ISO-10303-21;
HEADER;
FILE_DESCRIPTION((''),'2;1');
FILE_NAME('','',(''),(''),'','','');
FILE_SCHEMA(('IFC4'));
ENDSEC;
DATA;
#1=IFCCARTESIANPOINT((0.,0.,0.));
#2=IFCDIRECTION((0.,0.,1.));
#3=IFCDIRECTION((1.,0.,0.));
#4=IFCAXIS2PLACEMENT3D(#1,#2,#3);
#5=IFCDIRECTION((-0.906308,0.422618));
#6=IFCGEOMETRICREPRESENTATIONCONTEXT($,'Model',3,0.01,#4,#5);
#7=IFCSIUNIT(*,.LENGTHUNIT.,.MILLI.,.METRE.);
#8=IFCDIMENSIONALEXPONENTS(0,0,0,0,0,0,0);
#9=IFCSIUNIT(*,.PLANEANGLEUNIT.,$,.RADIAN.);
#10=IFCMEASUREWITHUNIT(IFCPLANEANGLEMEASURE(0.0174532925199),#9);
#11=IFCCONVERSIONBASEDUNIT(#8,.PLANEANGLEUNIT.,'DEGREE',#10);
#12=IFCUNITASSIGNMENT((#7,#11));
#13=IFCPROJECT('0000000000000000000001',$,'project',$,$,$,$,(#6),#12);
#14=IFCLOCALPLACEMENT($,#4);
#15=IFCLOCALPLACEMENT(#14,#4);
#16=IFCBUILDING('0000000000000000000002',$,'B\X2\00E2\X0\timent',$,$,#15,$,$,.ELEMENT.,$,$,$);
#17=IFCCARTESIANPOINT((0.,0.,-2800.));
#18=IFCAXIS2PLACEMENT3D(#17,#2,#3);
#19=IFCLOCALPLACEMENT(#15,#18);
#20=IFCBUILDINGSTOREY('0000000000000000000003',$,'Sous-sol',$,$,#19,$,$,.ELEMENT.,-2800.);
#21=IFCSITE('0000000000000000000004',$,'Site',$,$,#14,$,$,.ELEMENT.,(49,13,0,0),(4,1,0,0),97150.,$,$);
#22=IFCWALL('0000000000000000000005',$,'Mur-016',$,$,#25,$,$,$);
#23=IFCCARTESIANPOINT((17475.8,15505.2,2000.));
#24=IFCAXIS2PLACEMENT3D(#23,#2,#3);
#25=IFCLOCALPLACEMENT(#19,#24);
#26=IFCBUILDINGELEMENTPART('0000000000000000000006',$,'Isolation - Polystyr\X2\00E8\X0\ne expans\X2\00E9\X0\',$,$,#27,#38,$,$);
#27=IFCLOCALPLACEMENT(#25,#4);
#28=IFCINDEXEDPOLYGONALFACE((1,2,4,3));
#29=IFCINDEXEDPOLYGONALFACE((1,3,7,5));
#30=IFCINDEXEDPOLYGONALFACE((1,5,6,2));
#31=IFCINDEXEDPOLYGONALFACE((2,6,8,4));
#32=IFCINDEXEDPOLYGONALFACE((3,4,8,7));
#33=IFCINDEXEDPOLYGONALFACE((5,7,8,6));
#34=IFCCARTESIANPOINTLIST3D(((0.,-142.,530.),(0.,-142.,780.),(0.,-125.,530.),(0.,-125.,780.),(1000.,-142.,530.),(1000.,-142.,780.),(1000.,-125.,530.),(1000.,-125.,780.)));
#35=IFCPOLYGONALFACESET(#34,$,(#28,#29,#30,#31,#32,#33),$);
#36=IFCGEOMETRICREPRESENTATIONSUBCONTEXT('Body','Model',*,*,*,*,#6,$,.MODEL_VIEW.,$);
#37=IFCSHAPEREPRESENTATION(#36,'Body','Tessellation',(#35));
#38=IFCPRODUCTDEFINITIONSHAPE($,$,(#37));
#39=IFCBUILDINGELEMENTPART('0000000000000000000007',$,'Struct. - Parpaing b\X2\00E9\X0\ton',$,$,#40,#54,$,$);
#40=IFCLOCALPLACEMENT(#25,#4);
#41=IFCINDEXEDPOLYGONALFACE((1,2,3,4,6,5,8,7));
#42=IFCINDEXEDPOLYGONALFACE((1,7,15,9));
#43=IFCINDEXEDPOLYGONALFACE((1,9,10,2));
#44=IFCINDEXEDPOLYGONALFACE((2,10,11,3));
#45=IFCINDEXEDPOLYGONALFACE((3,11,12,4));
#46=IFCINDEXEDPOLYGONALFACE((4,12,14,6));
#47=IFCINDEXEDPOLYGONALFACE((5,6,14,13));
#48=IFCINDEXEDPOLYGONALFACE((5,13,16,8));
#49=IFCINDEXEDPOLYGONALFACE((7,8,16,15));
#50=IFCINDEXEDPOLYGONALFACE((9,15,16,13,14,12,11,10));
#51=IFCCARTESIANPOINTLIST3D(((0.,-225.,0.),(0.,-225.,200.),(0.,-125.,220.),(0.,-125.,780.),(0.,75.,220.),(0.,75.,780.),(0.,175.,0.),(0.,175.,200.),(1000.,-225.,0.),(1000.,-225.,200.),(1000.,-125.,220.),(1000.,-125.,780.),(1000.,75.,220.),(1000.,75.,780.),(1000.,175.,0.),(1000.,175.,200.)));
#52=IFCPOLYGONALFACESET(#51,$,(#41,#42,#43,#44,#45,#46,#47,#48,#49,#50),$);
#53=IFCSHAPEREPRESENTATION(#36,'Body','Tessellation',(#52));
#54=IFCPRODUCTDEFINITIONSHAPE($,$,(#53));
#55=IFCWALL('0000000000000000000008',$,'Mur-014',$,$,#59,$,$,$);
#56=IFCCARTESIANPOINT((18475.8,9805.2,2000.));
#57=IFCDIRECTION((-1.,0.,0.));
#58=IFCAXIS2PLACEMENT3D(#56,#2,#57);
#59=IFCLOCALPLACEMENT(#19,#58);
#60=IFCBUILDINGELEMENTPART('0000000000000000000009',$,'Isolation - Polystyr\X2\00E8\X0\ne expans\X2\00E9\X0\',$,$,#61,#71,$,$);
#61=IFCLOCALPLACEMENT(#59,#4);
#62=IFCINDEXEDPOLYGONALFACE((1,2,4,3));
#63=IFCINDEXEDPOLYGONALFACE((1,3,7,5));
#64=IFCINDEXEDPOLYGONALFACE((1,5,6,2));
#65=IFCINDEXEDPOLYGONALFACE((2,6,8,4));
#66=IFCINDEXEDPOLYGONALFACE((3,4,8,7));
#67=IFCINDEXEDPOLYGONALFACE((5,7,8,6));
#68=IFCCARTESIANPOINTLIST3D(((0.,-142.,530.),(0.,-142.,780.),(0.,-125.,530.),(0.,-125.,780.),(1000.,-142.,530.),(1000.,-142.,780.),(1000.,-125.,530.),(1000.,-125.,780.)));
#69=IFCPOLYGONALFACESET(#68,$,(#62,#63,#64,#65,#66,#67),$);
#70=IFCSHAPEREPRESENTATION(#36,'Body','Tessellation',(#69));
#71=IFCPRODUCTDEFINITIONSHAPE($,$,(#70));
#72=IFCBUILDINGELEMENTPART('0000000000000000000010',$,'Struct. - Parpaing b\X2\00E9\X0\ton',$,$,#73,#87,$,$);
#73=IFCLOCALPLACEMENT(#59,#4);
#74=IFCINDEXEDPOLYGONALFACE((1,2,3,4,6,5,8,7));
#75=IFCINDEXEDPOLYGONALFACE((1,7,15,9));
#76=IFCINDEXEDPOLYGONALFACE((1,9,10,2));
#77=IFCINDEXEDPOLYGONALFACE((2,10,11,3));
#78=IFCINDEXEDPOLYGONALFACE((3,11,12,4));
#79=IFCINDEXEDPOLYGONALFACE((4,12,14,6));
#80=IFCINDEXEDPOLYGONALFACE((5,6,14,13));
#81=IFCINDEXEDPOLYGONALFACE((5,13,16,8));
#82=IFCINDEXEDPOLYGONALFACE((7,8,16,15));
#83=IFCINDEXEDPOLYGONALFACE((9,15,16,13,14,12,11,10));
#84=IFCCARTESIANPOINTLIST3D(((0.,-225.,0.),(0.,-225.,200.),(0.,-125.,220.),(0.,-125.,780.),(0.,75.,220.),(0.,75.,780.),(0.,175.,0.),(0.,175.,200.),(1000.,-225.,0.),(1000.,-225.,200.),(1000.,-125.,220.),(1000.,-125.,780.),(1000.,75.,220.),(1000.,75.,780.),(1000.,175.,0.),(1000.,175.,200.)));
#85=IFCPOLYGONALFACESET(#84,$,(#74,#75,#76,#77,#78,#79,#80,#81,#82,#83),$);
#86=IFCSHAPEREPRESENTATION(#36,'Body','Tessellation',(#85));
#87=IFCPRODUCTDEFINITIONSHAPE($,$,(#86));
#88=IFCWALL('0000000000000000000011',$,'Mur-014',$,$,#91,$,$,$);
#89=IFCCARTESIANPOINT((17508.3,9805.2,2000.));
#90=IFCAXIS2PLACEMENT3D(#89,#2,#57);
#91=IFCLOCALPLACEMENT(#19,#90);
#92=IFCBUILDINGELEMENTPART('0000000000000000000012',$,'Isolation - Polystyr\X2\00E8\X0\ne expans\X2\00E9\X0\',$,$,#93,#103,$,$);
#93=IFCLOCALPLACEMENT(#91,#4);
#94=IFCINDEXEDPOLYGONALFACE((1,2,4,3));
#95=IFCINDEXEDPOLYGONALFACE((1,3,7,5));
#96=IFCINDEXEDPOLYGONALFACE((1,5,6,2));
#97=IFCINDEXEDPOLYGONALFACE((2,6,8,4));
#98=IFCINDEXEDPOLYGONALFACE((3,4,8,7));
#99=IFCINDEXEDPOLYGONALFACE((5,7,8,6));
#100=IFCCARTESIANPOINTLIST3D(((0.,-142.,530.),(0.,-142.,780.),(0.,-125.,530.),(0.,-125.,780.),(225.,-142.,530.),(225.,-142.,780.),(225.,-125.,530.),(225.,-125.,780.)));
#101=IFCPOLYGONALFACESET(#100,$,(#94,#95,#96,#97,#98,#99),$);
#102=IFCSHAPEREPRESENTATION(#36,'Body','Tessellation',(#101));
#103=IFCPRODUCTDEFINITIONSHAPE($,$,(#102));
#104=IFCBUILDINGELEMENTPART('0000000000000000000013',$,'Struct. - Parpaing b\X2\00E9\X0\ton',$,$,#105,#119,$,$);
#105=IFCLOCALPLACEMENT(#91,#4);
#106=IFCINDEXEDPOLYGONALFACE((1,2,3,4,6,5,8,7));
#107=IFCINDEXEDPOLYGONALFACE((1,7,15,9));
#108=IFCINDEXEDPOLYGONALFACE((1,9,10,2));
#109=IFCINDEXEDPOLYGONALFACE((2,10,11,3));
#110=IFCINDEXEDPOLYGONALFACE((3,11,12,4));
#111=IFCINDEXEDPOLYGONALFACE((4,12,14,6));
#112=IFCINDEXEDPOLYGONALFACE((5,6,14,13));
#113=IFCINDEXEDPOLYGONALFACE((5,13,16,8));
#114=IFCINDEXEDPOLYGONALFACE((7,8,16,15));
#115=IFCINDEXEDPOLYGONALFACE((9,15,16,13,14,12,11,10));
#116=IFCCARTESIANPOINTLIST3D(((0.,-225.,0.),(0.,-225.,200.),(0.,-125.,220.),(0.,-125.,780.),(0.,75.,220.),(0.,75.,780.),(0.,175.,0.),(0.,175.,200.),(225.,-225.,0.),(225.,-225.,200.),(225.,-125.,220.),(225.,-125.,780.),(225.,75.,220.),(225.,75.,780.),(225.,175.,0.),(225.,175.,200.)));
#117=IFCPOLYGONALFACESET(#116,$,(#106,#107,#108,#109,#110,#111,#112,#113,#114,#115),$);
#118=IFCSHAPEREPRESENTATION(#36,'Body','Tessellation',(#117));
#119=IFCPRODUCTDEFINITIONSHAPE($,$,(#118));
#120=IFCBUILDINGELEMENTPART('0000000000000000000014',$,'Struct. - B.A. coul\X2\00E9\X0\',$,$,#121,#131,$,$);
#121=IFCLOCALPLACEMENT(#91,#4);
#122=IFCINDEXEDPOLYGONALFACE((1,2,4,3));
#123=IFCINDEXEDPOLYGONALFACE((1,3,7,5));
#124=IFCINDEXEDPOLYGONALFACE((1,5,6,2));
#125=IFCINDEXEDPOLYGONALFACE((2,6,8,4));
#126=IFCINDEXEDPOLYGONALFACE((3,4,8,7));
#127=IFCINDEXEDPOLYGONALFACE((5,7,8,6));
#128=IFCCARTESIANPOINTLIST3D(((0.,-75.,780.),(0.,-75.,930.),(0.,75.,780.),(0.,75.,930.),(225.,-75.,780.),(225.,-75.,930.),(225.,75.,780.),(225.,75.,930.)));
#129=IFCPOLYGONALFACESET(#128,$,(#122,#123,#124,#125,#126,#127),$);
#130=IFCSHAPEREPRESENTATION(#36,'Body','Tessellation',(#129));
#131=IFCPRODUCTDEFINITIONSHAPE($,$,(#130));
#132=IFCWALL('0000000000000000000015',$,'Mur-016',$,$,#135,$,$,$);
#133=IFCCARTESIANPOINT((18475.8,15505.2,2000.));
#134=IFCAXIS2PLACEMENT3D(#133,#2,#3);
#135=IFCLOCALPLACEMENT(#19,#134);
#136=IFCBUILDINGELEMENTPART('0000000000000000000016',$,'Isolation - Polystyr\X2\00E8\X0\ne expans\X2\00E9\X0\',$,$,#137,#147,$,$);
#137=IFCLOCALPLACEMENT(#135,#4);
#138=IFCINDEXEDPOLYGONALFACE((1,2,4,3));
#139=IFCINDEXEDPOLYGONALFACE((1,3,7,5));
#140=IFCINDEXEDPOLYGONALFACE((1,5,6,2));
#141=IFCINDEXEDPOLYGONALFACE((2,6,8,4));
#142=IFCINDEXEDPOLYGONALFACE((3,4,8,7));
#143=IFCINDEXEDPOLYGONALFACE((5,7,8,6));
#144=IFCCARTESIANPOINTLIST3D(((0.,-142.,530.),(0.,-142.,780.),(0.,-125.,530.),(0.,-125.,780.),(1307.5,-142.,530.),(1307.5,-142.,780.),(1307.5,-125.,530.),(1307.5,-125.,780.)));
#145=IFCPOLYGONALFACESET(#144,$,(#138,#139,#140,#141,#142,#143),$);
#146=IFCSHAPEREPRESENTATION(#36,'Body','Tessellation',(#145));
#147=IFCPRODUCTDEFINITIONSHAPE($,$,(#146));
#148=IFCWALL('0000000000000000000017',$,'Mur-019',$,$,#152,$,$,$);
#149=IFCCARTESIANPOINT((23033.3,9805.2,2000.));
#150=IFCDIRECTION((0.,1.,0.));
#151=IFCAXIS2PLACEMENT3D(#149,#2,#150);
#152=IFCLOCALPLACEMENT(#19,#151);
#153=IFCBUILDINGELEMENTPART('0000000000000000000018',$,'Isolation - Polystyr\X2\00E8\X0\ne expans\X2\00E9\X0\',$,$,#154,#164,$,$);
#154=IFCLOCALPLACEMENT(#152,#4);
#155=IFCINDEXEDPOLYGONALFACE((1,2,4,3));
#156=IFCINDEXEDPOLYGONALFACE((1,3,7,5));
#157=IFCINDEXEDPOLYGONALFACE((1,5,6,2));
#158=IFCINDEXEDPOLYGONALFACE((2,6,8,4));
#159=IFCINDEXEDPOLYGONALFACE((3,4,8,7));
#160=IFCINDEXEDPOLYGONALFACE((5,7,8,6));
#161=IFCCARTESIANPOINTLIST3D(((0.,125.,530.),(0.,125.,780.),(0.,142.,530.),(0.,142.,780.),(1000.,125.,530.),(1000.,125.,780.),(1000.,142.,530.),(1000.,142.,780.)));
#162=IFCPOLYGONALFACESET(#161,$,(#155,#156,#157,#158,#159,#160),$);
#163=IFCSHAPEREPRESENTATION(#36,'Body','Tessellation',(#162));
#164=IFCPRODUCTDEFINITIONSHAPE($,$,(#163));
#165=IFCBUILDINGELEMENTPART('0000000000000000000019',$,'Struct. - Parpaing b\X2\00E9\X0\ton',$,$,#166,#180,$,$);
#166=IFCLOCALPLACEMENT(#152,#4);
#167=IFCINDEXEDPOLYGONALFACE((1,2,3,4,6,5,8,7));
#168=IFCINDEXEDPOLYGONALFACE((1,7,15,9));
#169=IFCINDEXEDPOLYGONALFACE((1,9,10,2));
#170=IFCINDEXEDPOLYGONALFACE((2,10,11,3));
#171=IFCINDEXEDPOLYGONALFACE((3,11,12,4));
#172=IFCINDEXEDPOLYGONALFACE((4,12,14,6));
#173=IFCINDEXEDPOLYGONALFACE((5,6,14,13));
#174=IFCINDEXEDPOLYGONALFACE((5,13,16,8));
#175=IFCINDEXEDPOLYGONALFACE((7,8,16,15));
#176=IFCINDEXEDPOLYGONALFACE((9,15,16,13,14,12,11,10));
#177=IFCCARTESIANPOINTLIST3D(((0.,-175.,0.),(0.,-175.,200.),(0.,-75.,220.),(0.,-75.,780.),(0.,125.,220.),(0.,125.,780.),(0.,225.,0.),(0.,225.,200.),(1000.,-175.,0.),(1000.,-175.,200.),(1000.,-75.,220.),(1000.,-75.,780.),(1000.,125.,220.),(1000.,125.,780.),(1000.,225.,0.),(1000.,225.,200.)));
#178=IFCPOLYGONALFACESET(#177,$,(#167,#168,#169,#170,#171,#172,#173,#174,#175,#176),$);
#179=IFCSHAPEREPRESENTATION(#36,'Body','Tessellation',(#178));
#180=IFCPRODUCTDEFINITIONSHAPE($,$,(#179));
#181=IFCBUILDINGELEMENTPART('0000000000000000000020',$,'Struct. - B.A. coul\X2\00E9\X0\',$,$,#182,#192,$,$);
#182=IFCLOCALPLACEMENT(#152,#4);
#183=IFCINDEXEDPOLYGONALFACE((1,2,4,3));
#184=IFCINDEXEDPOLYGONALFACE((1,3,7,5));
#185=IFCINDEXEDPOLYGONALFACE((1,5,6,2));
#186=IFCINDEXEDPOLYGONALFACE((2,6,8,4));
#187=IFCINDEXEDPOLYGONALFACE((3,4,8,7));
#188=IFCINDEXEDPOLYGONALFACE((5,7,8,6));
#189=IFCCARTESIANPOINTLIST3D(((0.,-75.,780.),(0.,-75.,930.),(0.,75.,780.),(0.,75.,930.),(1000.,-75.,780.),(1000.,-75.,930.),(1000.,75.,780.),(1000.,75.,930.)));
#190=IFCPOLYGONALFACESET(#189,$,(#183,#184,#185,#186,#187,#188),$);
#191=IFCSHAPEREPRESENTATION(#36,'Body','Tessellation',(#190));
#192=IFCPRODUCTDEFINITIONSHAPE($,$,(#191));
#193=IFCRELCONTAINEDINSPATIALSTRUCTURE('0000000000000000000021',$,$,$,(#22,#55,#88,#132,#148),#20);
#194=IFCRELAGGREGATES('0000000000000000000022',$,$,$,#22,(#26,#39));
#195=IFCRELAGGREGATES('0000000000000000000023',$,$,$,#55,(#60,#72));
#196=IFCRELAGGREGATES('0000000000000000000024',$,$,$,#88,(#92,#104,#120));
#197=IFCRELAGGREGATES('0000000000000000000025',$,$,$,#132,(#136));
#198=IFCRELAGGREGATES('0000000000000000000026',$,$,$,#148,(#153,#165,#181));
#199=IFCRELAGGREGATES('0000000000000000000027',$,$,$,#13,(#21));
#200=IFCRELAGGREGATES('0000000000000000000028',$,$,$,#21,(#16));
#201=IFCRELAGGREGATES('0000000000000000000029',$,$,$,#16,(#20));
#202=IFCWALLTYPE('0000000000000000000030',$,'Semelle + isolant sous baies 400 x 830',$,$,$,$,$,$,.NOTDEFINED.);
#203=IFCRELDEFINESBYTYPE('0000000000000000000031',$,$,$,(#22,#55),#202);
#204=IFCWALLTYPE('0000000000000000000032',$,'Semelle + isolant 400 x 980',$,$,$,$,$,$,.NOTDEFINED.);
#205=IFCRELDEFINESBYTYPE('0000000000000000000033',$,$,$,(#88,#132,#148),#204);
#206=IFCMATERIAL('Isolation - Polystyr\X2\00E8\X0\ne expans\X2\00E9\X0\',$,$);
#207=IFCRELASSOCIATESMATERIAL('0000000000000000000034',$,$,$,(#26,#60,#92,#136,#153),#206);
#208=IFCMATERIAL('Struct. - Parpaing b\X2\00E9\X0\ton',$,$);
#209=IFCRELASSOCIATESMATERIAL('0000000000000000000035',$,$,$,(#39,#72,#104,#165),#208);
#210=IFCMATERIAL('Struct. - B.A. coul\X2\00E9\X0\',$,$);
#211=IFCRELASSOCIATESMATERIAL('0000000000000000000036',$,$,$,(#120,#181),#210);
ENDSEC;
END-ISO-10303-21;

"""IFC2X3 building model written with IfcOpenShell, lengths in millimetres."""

from ifc_helpers import new_model, entity, si_unit, converted_unit, direction, frame, origin_with_axes, place, context, subcontext, project, spatial, polyline, outline, extrude, material, type_object, element, aggregate, save


model = new_model("IFC2X3")

# Units and contexts
model_context = context("Model", 3, precision=0.01, world=origin_with_axes(), true_north=direction((-0.906308, 0.422618)))
body_context = subcontext(model_context, "Body", "Model", "MODEL_VIEW")
ifc_project = project(units=[si_unit("LENGTHUNIT", "METRE", prefix="MILLI"), converted_unit("PLANEANGLEUNIT", "DEGREE", entity("IfcPlaneAngleMeasure", 0.0174532925199), si_unit("PLANEANGLEUNIT", "RADIAN"), dimensions=[0, 0, 0, 0, 0, 0, 0])], contexts=[model_context])

# Site, building, storey
site_placement = place(None, origin_with_axes())
site = spatial("IfcSite", under=ifc_project, at=site_placement, Name="Site", CompositionType="ELEMENT", RefLatitude=(49, 13, 0, 0), RefLongitude=(4, 1, 0, 0), RefElevation=97150.0)
building_placement = place(site_placement, origin_with_axes())
building = spatial("IfcBuilding", under=site, at=building_placement, Name="Bâtiment", CompositionType="ELEMENT")
storey_placement = place(building_placement, frame((0.0, 0.0, -2800.0), z_axis=(0.0, 0.0, 1.0), x_axis=(1.0, 0.0, 0.0)))
storey = spatial("IfcBuildingStorey", under=building, at=storey_placement, Name="Sous-sol", CompositionType="ELEMENT", Elevation=-2800.0)

# Walls, building element parts
ifc_material_1 = material(Name="Struct. - Parpaing béton")
wall_type_1 = type_object("IfcWallType", Name="Semelle + isolant sous baies 400 x 830", PredefinedType="NOTDEFINED")
wall_1_placement = place(storey_placement, frame((17475.8, 15505.2, 2000.0), z_axis=(0.0, 0.0, 1.0), x_axis=(1.0, 0.0, 0.0)))
wall_1 = element("IfcWall", 1, at=wall_1_placement, inside=storey, type_object=wall_type_1, Name="Mur-016")
ifc_material_2 = material(Name="Isolation - Polystyrène expansé")
building_element_part_1_placement = place(wall_1_placement, origin_with_axes())
building_element_part_1 = element("IfcBuildingElementPart", 2, at=building_element_part_1_placement, material=ifc_material_2, Name="Isolation - Polystyrène expansé", context=body_context, shape_type="SweptSolid", body=[
    extrude(outline(polyline([(125.0, 780.0), (125.0, 530.0), (142.0, 530.0), (142.0, 780.0), (125.0, 780.0)])), frame((0.0, 0.0, 0.0), z_axis=(-1.0, 0.0, 0.0), x_axis=(0.0, -1.0, 0.0)), (0.0, 0.0, -1.0), 1000.0),
])
building_element_part_2_placement = place(wall_1_placement, origin_with_axes())
building_element_part_2 = element("IfcBuildingElementPart", 3, at=building_element_part_2_placement, material=ifc_material_1, Name="Struct. - Parpaing béton", context=body_context, shape_type="SweptSolid", body=[
    extrude(outline(polyline([(-175.0, 200.0), (-175.0, 0.0), (225.0, 0.0), (225.0, 200.0), (125.0, 220.0), (125.0, 780.0), (-75.0, 780.0), (-75.0, 220.0), (-175.0, 200.0)])), frame((0.0, 0.0, 0.0), z_axis=(-1.0, 0.0, 0.0), x_axis=(0.0, -1.0, 0.0)), (0.0, 0.0, -1.0), 1000.0),
])
aggregate(wall_1, [building_element_part_1, building_element_part_2])
wall_2_placement = place(storey_placement, frame((18475.8, 9805.2, 2000.0), z_axis=(0.0, 0.0, 1.0), x_axis=(-1.0, 0.0, 0.0)))
wall_2 = element("IfcWall", 4, at=wall_2_placement, inside=storey, type_object=wall_type_1, Name="Mur-014")
building_element_part_3_placement = place(wall_2_placement, origin_with_axes())
building_element_part_3 = element("IfcBuildingElementPart", 5, at=building_element_part_3_placement, material=ifc_material_2, Name="Isolation - Polystyrène expansé", context=body_context, shape_type="SweptSolid", body=[
    extrude(outline(polyline([(125.0, 780.0), (125.0, 530.0), (142.0, 530.0), (142.0, 780.0), (125.0, 780.0)])), frame((0.0, 0.0, 0.0), z_axis=(-1.0, 0.0, 0.0), x_axis=(0.0, -1.0, 0.0)), (0.0, 0.0, -1.0), 1000.0),
])
building_element_part_4_placement = place(wall_2_placement, origin_with_axes())
building_element_part_4 = element("IfcBuildingElementPart", 6, at=building_element_part_4_placement, material=ifc_material_1, Name="Struct. - Parpaing béton", context=body_context, shape_type="SweptSolid", body=[
    extrude(outline(polyline([(-175.0, 200.0), (-175.0, 0.0), (225.0, 0.0), (225.0, 200.0), (125.0, 220.0), (125.0, 780.0), (-75.0, 780.0), (-75.0, 220.0), (-175.0, 200.0)])), frame((0.0, 0.0, 0.0), z_axis=(-1.0, 0.0, 0.0), x_axis=(0.0, -1.0, 0.0)), (0.0, 0.0, -1.0), 1000.0),
])
aggregate(wall_2, [building_element_part_3, building_element_part_4])
wall_type_2 = type_object("IfcWallType", Name="Semelle + isolant 400 x 980", PredefinedType="NOTDEFINED")
wall_3_placement = place(storey_placement, frame((17508.3, 9805.2, 2000.0), z_axis=(0.0, 0.0, 1.0), x_axis=(-1.0, 0.0, 0.0)))
wall_3 = element("IfcWall", 7, at=wall_3_placement, inside=storey, type_object=wall_type_2, Name="Mur-014")
building_element_part_5_placement = place(wall_3_placement, origin_with_axes())
building_element_part_5 = element("IfcBuildingElementPart", 8, at=building_element_part_5_placement, material=ifc_material_2, Name="Isolation - Polystyrène expansé", context=body_context, shape_type="SweptSolid", body=[
    extrude(outline(polyline([(125.0, 780.0), (125.0, 530.0), (142.0, 530.0), (142.0, 780.0), (125.0, 780.0)])), frame((0.0, 0.0, 0.0), z_axis=(-1.0, 0.0, 0.0), x_axis=(0.0, -1.0, 0.0)), (0.0, 0.0, -1.0), 225.0),
])
building_element_part_6_placement = place(wall_3_placement, origin_with_axes())
building_element_part_6 = element("IfcBuildingElementPart", 9, at=building_element_part_6_placement, material=ifc_material_1, Name="Struct. - Parpaing béton", context=body_context, shape_type="SweptSolid", body=[
    extrude(outline(polyline([(-75.0, 220.0), (-175.0, 200.0), (-175.0, 0.0), (225.0, 0.0), (225.0, 200.0), (125.0, 220.0), (125.0, 780.0), (-75.0, 780.0), (-75.0, 220.0)])), frame((0.0, 0.0, 0.0), z_axis=(-1.0, 0.0, 0.0), x_axis=(0.0, -1.0, 0.0)), (0.0, 0.0, -1.0), 225.0),
])
ifc_material_3 = material(Name="Struct. - B.A. coulé")
building_element_part_7_placement = place(wall_3_placement, origin_with_axes())
building_element_part_7 = element("IfcBuildingElementPart", 10, at=building_element_part_7_placement, material=ifc_material_3, Name="Struct. - B.A. coulé", context=body_context, shape_type="SweptSolid", body=[
    extrude(outline(polyline([(75.0, 780.0), (75.0, 930.0), (-75.0, 930.0), (-75.0, 780.0), (75.0, 780.0)])), frame((0.0, 0.0, 0.0), z_axis=(-1.0, 0.0, 0.0), x_axis=(0.0, -1.0, 0.0)), (0.0, 0.0, -1.0), 225.0),
])
aggregate(wall_3, [building_element_part_5, building_element_part_6, building_element_part_7])
wall_4_placement = place(storey_placement, frame((18475.8, 15505.2, 2000.0), z_axis=(0.0, 0.0, 1.0), x_axis=(1.0, 0.0, 0.0)))
wall_4 = element("IfcWall", 11, at=wall_4_placement, inside=storey, type_object=wall_type_2, Name="Mur-016")
building_element_part_8_placement = place(wall_4_placement, origin_with_axes())
building_element_part_8 = element("IfcBuildingElementPart", 12, at=building_element_part_8_placement, material=ifc_material_2, Name="Isolation - Polystyrène expansé", context=body_context, shape_type="SweptSolid", body=[
    extrude(outline(polyline([(125.0, 780.0), (125.0, 530.0), (142.0, 530.0), (142.0, 780.0), (125.0, 780.0)])), frame((0.0, 0.0, 0.0), z_axis=(-1.0, 0.0, 0.0), x_axis=(0.0, -1.0, 0.0)), (0.0, 0.0, -1.0), 1307.5),
])
aggregate(wall_4, [building_element_part_8])
wall_5_placement = place(storey_placement, frame((23033.3, 9805.2, 2000.0), z_axis=(0.0, 0.0, 1.0), x_axis=(0.0, 1.0, 0.0)))
wall_5 = element("IfcWall", 13, at=wall_5_placement, inside=storey, type_object=wall_type_2, Name="Mur-019")
building_element_part_9_placement = place(wall_5_placement, origin_with_axes())
building_element_part_9 = element("IfcBuildingElementPart", 14, at=building_element_part_9_placement, material=ifc_material_2, Name="Isolation - Polystyrène expansé", context=body_context, shape_type="SweptSolid", body=[
    extrude(outline(polyline([(125.0, 780.0), (125.0, 530.0), (142.0, 530.0), (142.0, 780.0), (125.0, 780.0)])), frame((0.0, 0.0, 0.0), z_axis=(1.0, 0.0, 0.0), x_axis=(0.0, 1.0, 0.0)), (0.0, 0.0, 1.0), 1000.0),
])
building_element_part_10_placement = place(wall_5_placement, origin_with_axes())
building_element_part_10 = element("IfcBuildingElementPart", 15, at=building_element_part_10_placement, material=ifc_material_1, Name="Struct. - Parpaing béton", context=body_context, shape_type="SweptSolid", body=[
    extrude(outline(polyline([(-75.0, 220.0), (-175.0, 200.0), (-175.0, 0.0), (225.0, 0.0), (225.0, 200.0), (125.0, 220.0), (125.0, 780.0), (-75.0, 780.0), (-75.0, 220.0)])), frame((0.0, 0.0, 0.0), z_axis=(1.0, 0.0, 0.0), x_axis=(0.0, 1.0, 0.0)), (0.0, 0.0, 1.0), 1000.0),
])
building_element_part_11_placement = place(wall_5_placement, origin_with_axes())
building_element_part_11 = element("IfcBuildingElementPart", 16, at=building_element_part_11_placement, material=ifc_material_3, Name="Struct. - B.A. coulé", context=body_context, shape_type="SweptSolid", body=[
    extrude(outline(polyline([(75.0, 780.0), (75.0, 930.0), (-75.0, 930.0), (-75.0, 780.0), (75.0, 780.0)])), frame((0.0, 0.0, 0.0), z_axis=(1.0, 0.0, 0.0), x_axis=(0.0, 1.0, 0.0)), (0.0, 0.0, 1.0), 1000.0),
])
aggregate(wall_5, [building_element_part_9, building_element_part_10, building_element_part_11])

save(model, "model.ifc")
